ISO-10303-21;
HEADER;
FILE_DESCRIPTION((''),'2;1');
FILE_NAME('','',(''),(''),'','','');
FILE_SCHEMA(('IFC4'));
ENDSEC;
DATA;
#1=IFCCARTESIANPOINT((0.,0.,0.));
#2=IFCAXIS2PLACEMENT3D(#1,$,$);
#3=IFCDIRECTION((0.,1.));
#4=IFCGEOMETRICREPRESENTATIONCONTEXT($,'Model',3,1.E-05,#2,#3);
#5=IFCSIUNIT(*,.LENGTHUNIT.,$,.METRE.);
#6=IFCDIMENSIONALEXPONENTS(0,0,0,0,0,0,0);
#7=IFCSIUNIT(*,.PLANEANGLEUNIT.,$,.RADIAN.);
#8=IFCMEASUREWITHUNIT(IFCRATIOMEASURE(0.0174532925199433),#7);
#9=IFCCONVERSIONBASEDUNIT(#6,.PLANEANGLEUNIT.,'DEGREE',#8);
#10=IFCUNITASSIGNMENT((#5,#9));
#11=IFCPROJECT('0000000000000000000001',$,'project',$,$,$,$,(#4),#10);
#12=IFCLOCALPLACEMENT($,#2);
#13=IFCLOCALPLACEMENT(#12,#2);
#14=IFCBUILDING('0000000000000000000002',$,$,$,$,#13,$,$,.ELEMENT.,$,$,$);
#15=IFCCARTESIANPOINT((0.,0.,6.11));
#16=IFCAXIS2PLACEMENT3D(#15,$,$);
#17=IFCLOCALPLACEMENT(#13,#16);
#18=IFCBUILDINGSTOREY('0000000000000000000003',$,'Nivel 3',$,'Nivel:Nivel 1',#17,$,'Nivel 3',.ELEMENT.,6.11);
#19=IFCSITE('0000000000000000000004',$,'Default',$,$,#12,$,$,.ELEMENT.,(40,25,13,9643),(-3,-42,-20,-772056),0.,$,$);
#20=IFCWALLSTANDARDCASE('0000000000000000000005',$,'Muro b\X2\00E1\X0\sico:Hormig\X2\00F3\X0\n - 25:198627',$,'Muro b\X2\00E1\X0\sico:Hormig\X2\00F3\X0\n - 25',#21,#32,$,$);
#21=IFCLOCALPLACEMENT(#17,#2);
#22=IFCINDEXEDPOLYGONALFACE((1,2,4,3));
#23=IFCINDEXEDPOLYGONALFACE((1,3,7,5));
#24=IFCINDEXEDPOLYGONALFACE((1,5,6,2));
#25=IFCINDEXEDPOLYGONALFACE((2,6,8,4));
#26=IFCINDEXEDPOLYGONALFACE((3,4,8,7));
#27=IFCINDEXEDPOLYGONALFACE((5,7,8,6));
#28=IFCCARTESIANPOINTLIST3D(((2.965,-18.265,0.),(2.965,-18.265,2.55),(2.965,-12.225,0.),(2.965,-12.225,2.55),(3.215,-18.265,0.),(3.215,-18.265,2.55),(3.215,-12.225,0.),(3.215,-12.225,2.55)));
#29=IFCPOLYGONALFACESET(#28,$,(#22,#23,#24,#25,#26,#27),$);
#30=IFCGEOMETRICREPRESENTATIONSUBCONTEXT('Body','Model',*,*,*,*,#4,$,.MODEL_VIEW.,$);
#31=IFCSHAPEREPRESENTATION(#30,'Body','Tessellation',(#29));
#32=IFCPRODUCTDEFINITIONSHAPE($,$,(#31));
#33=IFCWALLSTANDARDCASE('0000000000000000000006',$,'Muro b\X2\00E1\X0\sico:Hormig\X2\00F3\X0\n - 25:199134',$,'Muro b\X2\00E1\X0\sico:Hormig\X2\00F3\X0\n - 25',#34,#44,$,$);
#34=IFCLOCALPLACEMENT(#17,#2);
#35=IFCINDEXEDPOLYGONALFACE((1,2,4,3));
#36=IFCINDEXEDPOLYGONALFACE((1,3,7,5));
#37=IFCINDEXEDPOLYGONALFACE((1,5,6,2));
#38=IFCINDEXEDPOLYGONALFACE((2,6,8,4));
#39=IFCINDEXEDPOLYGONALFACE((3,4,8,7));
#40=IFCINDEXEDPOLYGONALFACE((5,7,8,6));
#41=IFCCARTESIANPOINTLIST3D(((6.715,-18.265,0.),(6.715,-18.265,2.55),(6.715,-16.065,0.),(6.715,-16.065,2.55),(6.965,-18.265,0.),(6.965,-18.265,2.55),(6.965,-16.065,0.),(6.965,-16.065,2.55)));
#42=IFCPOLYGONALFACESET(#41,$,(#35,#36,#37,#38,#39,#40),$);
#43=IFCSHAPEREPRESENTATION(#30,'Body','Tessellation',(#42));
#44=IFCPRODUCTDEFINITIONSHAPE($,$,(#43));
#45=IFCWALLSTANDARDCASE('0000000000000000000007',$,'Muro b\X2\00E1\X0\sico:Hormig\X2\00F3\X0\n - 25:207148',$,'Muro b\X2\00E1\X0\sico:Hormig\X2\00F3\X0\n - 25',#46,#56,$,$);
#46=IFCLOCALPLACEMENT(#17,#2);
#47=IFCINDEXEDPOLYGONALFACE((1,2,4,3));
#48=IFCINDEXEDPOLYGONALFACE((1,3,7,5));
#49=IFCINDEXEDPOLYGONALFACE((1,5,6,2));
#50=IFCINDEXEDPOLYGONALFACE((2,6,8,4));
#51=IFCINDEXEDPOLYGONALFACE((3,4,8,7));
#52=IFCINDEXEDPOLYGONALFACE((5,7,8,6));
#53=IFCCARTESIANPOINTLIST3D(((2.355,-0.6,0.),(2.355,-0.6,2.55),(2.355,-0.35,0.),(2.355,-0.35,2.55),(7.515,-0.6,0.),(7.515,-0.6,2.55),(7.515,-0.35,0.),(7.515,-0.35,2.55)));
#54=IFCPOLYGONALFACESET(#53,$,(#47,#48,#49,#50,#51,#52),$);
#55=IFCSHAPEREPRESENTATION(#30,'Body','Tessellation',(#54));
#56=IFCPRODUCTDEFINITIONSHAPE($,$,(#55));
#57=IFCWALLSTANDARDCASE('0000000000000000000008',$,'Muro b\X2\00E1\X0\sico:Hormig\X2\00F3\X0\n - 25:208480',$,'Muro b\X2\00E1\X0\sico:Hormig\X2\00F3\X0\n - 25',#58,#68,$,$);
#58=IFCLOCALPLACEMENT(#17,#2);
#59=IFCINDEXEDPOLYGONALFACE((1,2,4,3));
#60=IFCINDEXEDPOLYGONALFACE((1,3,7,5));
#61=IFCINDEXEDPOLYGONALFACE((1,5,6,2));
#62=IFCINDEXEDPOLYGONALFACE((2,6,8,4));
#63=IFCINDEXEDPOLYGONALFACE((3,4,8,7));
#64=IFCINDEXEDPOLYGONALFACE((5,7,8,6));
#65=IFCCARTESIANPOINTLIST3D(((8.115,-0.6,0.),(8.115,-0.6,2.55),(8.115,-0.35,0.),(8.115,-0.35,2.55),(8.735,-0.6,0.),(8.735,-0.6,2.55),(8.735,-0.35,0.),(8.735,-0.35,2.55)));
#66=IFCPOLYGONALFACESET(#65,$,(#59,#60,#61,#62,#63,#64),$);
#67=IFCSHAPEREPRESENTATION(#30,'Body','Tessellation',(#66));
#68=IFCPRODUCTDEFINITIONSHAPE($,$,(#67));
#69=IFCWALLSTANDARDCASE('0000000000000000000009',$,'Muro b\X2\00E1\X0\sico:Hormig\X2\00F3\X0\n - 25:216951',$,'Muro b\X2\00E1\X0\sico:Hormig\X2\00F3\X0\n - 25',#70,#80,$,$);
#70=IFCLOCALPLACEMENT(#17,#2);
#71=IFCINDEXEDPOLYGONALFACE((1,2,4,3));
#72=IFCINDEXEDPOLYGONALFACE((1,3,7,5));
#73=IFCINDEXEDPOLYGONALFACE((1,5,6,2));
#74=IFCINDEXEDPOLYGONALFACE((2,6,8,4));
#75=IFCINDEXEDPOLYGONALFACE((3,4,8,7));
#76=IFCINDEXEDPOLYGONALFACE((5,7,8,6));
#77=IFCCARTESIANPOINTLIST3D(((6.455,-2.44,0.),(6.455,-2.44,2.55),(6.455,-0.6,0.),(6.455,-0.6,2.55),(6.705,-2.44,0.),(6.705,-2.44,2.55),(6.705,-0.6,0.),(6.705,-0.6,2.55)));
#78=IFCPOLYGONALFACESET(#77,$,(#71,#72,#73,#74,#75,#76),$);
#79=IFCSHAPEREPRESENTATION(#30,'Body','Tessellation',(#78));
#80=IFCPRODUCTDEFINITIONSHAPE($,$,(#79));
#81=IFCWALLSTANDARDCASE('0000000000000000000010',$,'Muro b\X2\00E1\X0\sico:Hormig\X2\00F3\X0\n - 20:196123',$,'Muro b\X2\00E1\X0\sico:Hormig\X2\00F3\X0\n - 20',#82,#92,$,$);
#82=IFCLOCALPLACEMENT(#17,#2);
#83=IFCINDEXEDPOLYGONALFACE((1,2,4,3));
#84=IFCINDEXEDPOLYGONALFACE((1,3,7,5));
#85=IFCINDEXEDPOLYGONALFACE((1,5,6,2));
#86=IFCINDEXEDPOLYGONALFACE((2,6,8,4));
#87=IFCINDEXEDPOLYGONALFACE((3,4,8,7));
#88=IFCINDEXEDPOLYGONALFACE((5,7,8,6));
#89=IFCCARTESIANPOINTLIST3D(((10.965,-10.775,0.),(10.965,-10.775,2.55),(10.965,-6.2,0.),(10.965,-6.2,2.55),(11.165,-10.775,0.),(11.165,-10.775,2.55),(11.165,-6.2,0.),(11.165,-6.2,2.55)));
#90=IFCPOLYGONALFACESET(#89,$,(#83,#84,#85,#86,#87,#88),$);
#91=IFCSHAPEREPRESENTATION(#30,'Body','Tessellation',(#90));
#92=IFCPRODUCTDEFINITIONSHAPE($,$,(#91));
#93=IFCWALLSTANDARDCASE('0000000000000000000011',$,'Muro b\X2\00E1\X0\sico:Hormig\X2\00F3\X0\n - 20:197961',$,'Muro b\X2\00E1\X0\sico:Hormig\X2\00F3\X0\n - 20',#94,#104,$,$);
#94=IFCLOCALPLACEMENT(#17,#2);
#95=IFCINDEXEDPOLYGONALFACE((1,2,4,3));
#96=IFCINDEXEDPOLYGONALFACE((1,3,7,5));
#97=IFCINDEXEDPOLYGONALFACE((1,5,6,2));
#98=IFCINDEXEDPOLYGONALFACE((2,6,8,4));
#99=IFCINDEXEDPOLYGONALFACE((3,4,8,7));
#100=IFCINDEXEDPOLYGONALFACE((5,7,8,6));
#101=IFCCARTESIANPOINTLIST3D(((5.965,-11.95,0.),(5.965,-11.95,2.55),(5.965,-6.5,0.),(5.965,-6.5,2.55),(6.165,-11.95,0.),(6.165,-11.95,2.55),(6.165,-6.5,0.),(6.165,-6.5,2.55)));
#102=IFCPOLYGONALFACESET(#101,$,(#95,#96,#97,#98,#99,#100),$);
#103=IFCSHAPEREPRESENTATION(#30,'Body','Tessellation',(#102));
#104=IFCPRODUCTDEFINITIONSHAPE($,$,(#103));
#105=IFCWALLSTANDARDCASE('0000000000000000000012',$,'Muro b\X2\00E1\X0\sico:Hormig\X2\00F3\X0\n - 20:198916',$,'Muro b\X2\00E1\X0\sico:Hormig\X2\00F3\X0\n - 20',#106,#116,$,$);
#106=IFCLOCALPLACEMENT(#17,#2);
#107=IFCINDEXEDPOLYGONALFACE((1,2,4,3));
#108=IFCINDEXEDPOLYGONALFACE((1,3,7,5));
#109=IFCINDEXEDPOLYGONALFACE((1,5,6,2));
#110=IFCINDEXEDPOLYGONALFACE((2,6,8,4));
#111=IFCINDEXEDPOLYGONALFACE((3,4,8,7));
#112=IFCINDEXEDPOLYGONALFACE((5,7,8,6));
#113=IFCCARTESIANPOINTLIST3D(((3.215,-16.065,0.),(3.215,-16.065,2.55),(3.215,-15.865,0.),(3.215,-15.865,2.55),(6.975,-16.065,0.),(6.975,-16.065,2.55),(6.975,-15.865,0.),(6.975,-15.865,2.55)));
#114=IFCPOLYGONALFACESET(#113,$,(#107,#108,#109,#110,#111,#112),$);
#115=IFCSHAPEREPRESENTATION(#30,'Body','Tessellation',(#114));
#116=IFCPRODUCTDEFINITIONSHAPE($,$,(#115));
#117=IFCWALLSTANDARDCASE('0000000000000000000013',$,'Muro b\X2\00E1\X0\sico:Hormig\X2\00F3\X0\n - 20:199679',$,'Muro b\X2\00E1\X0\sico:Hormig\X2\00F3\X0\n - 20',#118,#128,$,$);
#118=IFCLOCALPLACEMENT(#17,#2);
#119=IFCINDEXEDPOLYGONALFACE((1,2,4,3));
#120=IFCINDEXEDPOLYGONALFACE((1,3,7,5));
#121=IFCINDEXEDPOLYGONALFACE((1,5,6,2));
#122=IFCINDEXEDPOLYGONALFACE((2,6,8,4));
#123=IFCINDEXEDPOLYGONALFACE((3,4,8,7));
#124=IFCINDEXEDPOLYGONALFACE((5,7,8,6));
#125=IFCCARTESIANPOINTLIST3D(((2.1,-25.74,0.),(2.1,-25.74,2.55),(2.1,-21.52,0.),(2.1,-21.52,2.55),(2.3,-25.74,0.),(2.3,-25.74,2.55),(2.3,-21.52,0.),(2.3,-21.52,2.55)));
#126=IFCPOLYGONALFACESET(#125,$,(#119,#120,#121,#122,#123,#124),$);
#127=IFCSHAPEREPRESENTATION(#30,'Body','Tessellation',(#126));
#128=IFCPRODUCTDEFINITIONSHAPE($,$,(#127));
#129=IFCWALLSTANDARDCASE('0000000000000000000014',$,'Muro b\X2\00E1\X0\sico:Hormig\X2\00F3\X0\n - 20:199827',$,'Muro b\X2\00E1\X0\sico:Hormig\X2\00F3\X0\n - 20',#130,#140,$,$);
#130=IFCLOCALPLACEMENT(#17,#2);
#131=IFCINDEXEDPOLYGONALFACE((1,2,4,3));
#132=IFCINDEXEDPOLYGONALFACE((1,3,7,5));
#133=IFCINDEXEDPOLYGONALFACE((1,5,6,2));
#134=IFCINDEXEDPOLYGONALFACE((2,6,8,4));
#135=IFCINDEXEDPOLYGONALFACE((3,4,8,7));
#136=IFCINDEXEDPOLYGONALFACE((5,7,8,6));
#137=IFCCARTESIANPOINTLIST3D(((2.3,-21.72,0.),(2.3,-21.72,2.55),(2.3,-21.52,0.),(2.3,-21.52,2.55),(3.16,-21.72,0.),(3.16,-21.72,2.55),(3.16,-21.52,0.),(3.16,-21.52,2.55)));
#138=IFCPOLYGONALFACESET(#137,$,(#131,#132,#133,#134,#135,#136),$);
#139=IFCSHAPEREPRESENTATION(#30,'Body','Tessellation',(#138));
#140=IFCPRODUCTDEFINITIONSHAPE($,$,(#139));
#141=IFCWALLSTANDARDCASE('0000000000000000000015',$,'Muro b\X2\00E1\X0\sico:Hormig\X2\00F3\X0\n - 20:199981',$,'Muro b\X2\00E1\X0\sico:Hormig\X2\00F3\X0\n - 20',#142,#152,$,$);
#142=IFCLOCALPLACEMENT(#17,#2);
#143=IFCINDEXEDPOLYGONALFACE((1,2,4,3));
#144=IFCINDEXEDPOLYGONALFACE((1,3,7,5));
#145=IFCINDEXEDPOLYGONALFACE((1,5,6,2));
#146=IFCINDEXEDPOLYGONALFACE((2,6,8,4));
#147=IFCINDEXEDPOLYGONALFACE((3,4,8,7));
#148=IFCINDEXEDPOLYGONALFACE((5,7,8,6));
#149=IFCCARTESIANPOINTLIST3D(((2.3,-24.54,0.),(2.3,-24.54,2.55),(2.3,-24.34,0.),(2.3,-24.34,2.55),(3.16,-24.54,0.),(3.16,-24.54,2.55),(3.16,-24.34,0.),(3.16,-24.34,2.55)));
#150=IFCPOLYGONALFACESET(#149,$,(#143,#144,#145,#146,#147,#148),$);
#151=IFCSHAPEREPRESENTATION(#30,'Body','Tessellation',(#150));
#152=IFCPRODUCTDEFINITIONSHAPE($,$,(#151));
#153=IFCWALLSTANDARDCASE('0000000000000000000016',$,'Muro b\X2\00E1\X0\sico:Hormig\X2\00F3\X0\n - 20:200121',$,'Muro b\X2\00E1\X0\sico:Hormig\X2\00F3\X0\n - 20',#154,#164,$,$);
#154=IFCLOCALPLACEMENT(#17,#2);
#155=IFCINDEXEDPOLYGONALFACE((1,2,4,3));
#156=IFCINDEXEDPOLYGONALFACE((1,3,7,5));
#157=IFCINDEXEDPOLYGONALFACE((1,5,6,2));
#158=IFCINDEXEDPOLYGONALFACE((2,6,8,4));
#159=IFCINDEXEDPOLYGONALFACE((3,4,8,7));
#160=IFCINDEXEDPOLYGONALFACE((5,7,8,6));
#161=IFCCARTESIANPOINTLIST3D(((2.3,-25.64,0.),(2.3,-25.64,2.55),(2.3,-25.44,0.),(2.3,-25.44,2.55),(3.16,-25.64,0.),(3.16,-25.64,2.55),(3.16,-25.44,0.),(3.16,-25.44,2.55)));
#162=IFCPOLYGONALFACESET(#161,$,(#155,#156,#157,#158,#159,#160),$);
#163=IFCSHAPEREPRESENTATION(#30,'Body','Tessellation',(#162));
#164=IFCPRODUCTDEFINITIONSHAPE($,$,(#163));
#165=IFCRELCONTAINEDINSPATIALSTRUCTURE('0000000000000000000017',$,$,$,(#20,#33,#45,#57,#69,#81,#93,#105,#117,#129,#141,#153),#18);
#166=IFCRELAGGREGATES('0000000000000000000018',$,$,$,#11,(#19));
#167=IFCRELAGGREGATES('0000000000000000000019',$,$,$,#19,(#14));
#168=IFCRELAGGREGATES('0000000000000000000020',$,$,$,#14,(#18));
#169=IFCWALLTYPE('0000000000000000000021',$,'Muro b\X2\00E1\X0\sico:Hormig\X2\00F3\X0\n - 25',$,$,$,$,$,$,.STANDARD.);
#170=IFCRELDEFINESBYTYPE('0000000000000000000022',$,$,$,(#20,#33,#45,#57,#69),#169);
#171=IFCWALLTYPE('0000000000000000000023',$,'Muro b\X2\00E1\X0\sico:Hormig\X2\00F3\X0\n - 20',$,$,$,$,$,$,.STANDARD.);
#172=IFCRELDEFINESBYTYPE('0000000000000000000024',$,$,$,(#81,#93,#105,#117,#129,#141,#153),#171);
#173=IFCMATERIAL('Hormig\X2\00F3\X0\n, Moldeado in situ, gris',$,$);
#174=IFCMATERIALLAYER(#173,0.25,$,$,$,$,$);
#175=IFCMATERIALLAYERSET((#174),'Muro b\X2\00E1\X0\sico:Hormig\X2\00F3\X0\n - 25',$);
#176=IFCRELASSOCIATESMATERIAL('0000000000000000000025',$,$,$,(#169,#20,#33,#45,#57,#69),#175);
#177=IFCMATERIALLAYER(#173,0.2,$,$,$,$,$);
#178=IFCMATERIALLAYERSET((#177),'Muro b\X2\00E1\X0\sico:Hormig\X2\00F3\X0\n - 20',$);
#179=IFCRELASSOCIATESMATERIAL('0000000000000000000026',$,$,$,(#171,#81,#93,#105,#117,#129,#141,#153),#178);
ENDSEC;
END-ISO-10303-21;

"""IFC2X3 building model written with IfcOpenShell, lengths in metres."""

from ifc_helpers import new_model, entity, si_unit, converted_unit, direction, frame, frame_2d, origin, place, context, subcontext, project, spatial, rectangle, extrude, material, layer, layer_set, layer_usage, type_object, element, save


model = new_model("IFC2X3")

# Units and contexts
model_context = context("Model", 3, precision=1e-05, world=origin(), true_north=direction((0.0, 1.0)))
body_context = subcontext(model_context, "Body", "Model", "MODEL_VIEW")
ifc_project = project(units=[si_unit("LENGTHUNIT", "METRE"), converted_unit("PLANEANGLEUNIT", "DEGREE", entity("IfcRatioMeasure", 0.0174532925199433), si_unit("PLANEANGLEUNIT", "RADIAN"), dimensions=[0, 0, 0, 0, 0, 0, 0])], contexts=[model_context])

# Site, building, storey
site_placement = place(None, origin())
site = spatial("IfcSite", under=ifc_project, at=site_placement, Name="Default", CompositionType="ELEMENT", RefLatitude=(40, 25, 13, 9643), RefLongitude=(-3, -42, -20, -772056), RefElevation=0.0)
building_placement = place(site_placement, origin())
building = spatial("IfcBuilding", under=site, at=building_placement, CompositionType="ELEMENT")
storey_placement = place(building_placement, frame((0.0, 0.0, 6.11)))
storey = spatial("IfcBuildingStorey", under=building, at=storey_placement, Name="Nivel 3", ObjectType="Nivel:Nivel 1", LongName="Nivel 3", CompositionType="ELEMENT", Elevation=6.11)

# Walls
ifc_material = material(Name="Hormigón, Moldeado in situ, gris")
ifc_layer_1 = layer(ifc_material, 0.25)
ifc_layer_set_1 = layer_set([ifc_layer_1], Name="Muro básico:Hormigón - 25")
wall_type_1 = type_object("IfcWallType", Name="Muro básico:Hormigón - 25", PredefinedType="STANDARD", material=ifc_layer_set_1)
ifc_layer_usage_1 = layer_usage(ifc_layer_set_1, "AXIS2", "NEGATIVE", 0.125)
wall_1_placement = place(storey_placement, frame((3.09, -18.265, 0.0), z_axis=(0.0, 0.0, 1.0), x_axis=(0.0, 1.0, 0.0)))
element("IfcWallStandardCase", 1, at=wall_1_placement, inside=storey, type_object=wall_type_1, material=ifc_layer_usage_1, Name="Muro básico:Hormigón - 25:198627", ObjectType="Muro básico:Hormigón - 25", context=body_context, shape_type="SweptSolid", body=[
    extrude(rectangle(XDim=6.04, YDim=0.25, at=frame_2d((3.02, 0.0), x_axis=(-1.0, 0.0))), origin(), (0.0, 0.0, 1.0), 2.55),
])
ifc_layer_usage_2 = layer_usage(ifc_layer_set_1, "AXIS2", "NEGATIVE", 0.125)
wall_2_placement = place(storey_placement, frame((6.84, -18.265, 0.0), z_axis=(0.0, 0.0, 1.0), x_axis=(0.0, 1.0, 0.0)))
element("IfcWallStandardCase", 2, at=wall_2_placement, inside=storey, type_object=wall_type_1, material=ifc_layer_usage_2, Name="Muro básico:Hormigón - 25:199134", ObjectType="Muro básico:Hormigón - 25", context=body_context, shape_type="SweptSolid", body=[
    extrude(rectangle(XDim=2.2, YDim=0.25, at=frame_2d((1.1, 0.0), x_axis=(-1.0, 0.0))), origin(), (0.0, 0.0, 1.0), 2.55),
])
ifc_layer_usage_3 = layer_usage(ifc_layer_set_1, "AXIS2", "NEGATIVE", 0.125)
wall_3_placement = place(storey_placement, frame((2.355, -0.475, 0.0)))
element("IfcWallStandardCase", 3, at=wall_3_placement, inside=storey, type_object=wall_type_1, material=ifc_layer_usage_3, Name="Muro básico:Hormigón - 25:207148", ObjectType="Muro básico:Hormigón - 25", context=body_context, shape_type="SweptSolid", body=[
    extrude(rectangle(XDim=5.16, YDim=0.25, at=frame_2d((2.58, 0.0), x_axis=(-1.0, 0.0))), origin(), (0.0, 0.0, 1.0), 2.55),
])
ifc_layer_usage_4 = layer_usage(ifc_layer_set_1, "AXIS2", "NEGATIVE", 0.125)
wall_4_placement = place(storey_placement, frame((8.115, -0.475, 0.0)))
element("IfcWallStandardCase", 4, at=wall_4_placement, inside=storey, type_object=wall_type_1, material=ifc_layer_usage_4, Name="Muro básico:Hormigón - 25:208480", ObjectType="Muro básico:Hormigón - 25", context=body_context, shape_type="SweptSolid", body=[
    extrude(rectangle(XDim=0.62, YDim=0.25, at=frame_2d((0.31, 0.0), x_axis=(-1.0, 0.0))), origin(), (0.0, 0.0, 1.0), 2.55),
])
ifc_layer_usage_5 = layer_usage(ifc_layer_set_1, "AXIS2", "NEGATIVE", 0.125)
wall_5_placement = place(storey_placement, frame((6.58, -2.44, 0.0), z_axis=(0.0, 0.0, 1.0), x_axis=(0.0, 1.0, 0.0)))
element("IfcWallStandardCase", 5, at=wall_5_placement, inside=storey, type_object=wall_type_1, material=ifc_layer_usage_5, Name="Muro básico:Hormigón - 25:216951", ObjectType="Muro básico:Hormigón - 25", context=body_context, shape_type="SweptSolid", body=[
    extrude(rectangle(XDim=1.84, YDim=0.25, at=frame_2d((0.92, 0.0), x_axis=(-1.0, 0.0))), origin(), (0.0, 0.0, 1.0), 2.55),
])
ifc_layer_2 = layer(ifc_material, 0.2)
ifc_layer_set_2 = layer_set([ifc_layer_2], Name="Muro básico:Hormigón - 20")
ifc_layer_usage_6 = layer_usage(ifc_layer_set_2, "AXIS2", "NEGATIVE", 0.1)
wall_type_2 = type_object("IfcWallType", Name="Muro básico:Hormigón - 20", PredefinedType="STANDARD", material=ifc_layer_set_2)
wall_6_placement = place(storey_placement, frame((11.065, -10.775, 0.0), z_axis=(0.0, 0.0, 1.0), x_axis=(0.0, 1.0, 0.0)))
element("IfcWallStandardCase", 6, at=wall_6_placement, inside=storey, type_object=wall_type_2, material=ifc_layer_usage_6, Name="Muro básico:Hormigón - 20:196123", ObjectType="Muro básico:Hormigón - 20", context=body_context, shape_type="SweptSolid", body=[
    extrude(rectangle(XDim=4.575, YDim=0.2, at=frame_2d((2.2875, 0.0), x_axis=(-1.0, 0.0))), origin(), (0.0, 0.0, 1.0), 2.55),
])
ifc_layer_usage_7 = layer_usage(ifc_layer_set_2, "AXIS2", "NEGATIVE", 0.1)
wall_7_placement = place(storey_placement, frame((6.065, -11.95, 0.0), z_axis=(0.0, 0.0, 1.0), x_axis=(0.0, 1.0, 0.0)))
element("IfcWallStandardCase", 7, at=wall_7_placement, inside=storey, type_object=wall_type_2, material=ifc_layer_usage_7, Name="Muro básico:Hormigón - 20:197961", ObjectType="Muro básico:Hormigón - 20", context=body_context, shape_type="SweptSolid", body=[
    extrude(rectangle(XDim=5.45, YDim=0.2, at=frame_2d((2.725, 0.0), x_axis=(-1.0, 0.0))), origin(), (0.0, 0.0, 1.0), 2.55),
])
ifc_layer_usage_8 = layer_usage(ifc_layer_set_2, "AXIS2", "NEGATIVE", 0.1)
wall_8_placement = place(storey_placement, frame((3.215, -15.965, 0.0)))
element("IfcWallStandardCase", 8, at=wall_8_placement, inside=storey, type_object=wall_type_2, material=ifc_layer_usage_8, Name="Muro básico:Hormigón - 20:198916", ObjectType="Muro básico:Hormigón - 20", context=body_context, shape_type="SweptSolid", body=[
    extrude(rectangle(XDim=3.76, YDim=0.2, at=frame_2d((1.88, 0.0), x_axis=(-1.0, 0.0))), origin(), (0.0, 0.0, 1.0), 2.55),
])
ifc_layer_usage_9 = layer_usage(ifc_layer_set_2, "AXIS2", "NEGATIVE", 0.1)
wall_9_placement = place(storey_placement, frame((2.2, -25.74, 0.0), z_axis=(0.0, 0.0, 1.0), x_axis=(0.0, 1.0, 0.0)))
element("IfcWallStandardCase", 9, at=wall_9_placement, inside=storey, type_object=wall_type_2, material=ifc_layer_usage_9, Name="Muro básico:Hormigón - 20:199679", ObjectType="Muro básico:Hormigón - 20", context=body_context, shape_type="SweptSolid", body=[
    extrude(rectangle(XDim=4.22, YDim=0.2, at=frame_2d((2.11, 0.0), x_axis=(-1.0, 0.0))), origin(), (0.0, 0.0, 1.0), 2.55),
])
ifc_layer_usage_10 = layer_usage(ifc_layer_set_2, "AXIS2", "NEGATIVE", 0.1)
wall_10_placement = place(storey_placement, frame((3.16, -21.62, 0.0), z_axis=(0.0, 0.0, 1.0), x_axis=(-1.0, 0.0, 0.0)))
element("IfcWallStandardCase", 10, at=wall_10_placement, inside=storey, type_object=wall_type_2, material=ifc_layer_usage_10, Name="Muro básico:Hormigón - 20:199827", ObjectType="Muro básico:Hormigón - 20", context=body_context, shape_type="SweptSolid", body=[
    extrude(rectangle(XDim=0.86, YDim=0.2, at=frame_2d((0.43, 0.0), x_axis=(-1.0, 0.0))), origin(), (0.0, 0.0, 1.0), 2.55),
])
ifc_layer_usage_11 = layer_usage(ifc_layer_set_2, "AXIS2", "NEGATIVE", 0.1)
wall_11_placement = place(storey_placement, frame((3.16, -24.44, 0.0), z_axis=(0.0, 0.0, 1.0), x_axis=(-1.0, 0.0, 0.0)))
element("IfcWallStandardCase", 11, at=wall_11_placement, inside=storey, type_object=wall_type_2, material=ifc_layer_usage_11, Name="Muro básico:Hormigón - 20:199981", ObjectType="Muro básico:Hormigón - 20", context=body_context, shape_type="SweptSolid", body=[
    extrude(rectangle(XDim=0.86, YDim=0.2, at=frame_2d((0.43, 0.0), x_axis=(-1.0, 0.0))), origin(), (0.0, 0.0, 1.0), 2.55),
])
ifc_layer_usage_12 = layer_usage(ifc_layer_set_2, "AXIS2", "NEGATIVE", 0.1)
wall_12_placement = place(storey_placement, frame((3.16, -25.54, 0.0), z_axis=(0.0, 0.0, 1.0), x_axis=(-1.0, 0.0, 0.0)))
element("IfcWallStandardCase", 12, at=wall_12_placement, inside=storey, type_object=wall_type_2, material=ifc_layer_usage_12, Name="Muro básico:Hormigón - 20:200121", ObjectType="Muro básico:Hormigón - 20", context=body_context, shape_type="SweptSolid", body=[
    extrude(rectangle(XDim=0.86, YDim=0.2, at=frame_2d((0.43, 0.0), x_axis=(-1.0, 0.0))), origin(), (0.0, 0.0, 1.0), 2.55),
])

save(model, "model.ifc")
